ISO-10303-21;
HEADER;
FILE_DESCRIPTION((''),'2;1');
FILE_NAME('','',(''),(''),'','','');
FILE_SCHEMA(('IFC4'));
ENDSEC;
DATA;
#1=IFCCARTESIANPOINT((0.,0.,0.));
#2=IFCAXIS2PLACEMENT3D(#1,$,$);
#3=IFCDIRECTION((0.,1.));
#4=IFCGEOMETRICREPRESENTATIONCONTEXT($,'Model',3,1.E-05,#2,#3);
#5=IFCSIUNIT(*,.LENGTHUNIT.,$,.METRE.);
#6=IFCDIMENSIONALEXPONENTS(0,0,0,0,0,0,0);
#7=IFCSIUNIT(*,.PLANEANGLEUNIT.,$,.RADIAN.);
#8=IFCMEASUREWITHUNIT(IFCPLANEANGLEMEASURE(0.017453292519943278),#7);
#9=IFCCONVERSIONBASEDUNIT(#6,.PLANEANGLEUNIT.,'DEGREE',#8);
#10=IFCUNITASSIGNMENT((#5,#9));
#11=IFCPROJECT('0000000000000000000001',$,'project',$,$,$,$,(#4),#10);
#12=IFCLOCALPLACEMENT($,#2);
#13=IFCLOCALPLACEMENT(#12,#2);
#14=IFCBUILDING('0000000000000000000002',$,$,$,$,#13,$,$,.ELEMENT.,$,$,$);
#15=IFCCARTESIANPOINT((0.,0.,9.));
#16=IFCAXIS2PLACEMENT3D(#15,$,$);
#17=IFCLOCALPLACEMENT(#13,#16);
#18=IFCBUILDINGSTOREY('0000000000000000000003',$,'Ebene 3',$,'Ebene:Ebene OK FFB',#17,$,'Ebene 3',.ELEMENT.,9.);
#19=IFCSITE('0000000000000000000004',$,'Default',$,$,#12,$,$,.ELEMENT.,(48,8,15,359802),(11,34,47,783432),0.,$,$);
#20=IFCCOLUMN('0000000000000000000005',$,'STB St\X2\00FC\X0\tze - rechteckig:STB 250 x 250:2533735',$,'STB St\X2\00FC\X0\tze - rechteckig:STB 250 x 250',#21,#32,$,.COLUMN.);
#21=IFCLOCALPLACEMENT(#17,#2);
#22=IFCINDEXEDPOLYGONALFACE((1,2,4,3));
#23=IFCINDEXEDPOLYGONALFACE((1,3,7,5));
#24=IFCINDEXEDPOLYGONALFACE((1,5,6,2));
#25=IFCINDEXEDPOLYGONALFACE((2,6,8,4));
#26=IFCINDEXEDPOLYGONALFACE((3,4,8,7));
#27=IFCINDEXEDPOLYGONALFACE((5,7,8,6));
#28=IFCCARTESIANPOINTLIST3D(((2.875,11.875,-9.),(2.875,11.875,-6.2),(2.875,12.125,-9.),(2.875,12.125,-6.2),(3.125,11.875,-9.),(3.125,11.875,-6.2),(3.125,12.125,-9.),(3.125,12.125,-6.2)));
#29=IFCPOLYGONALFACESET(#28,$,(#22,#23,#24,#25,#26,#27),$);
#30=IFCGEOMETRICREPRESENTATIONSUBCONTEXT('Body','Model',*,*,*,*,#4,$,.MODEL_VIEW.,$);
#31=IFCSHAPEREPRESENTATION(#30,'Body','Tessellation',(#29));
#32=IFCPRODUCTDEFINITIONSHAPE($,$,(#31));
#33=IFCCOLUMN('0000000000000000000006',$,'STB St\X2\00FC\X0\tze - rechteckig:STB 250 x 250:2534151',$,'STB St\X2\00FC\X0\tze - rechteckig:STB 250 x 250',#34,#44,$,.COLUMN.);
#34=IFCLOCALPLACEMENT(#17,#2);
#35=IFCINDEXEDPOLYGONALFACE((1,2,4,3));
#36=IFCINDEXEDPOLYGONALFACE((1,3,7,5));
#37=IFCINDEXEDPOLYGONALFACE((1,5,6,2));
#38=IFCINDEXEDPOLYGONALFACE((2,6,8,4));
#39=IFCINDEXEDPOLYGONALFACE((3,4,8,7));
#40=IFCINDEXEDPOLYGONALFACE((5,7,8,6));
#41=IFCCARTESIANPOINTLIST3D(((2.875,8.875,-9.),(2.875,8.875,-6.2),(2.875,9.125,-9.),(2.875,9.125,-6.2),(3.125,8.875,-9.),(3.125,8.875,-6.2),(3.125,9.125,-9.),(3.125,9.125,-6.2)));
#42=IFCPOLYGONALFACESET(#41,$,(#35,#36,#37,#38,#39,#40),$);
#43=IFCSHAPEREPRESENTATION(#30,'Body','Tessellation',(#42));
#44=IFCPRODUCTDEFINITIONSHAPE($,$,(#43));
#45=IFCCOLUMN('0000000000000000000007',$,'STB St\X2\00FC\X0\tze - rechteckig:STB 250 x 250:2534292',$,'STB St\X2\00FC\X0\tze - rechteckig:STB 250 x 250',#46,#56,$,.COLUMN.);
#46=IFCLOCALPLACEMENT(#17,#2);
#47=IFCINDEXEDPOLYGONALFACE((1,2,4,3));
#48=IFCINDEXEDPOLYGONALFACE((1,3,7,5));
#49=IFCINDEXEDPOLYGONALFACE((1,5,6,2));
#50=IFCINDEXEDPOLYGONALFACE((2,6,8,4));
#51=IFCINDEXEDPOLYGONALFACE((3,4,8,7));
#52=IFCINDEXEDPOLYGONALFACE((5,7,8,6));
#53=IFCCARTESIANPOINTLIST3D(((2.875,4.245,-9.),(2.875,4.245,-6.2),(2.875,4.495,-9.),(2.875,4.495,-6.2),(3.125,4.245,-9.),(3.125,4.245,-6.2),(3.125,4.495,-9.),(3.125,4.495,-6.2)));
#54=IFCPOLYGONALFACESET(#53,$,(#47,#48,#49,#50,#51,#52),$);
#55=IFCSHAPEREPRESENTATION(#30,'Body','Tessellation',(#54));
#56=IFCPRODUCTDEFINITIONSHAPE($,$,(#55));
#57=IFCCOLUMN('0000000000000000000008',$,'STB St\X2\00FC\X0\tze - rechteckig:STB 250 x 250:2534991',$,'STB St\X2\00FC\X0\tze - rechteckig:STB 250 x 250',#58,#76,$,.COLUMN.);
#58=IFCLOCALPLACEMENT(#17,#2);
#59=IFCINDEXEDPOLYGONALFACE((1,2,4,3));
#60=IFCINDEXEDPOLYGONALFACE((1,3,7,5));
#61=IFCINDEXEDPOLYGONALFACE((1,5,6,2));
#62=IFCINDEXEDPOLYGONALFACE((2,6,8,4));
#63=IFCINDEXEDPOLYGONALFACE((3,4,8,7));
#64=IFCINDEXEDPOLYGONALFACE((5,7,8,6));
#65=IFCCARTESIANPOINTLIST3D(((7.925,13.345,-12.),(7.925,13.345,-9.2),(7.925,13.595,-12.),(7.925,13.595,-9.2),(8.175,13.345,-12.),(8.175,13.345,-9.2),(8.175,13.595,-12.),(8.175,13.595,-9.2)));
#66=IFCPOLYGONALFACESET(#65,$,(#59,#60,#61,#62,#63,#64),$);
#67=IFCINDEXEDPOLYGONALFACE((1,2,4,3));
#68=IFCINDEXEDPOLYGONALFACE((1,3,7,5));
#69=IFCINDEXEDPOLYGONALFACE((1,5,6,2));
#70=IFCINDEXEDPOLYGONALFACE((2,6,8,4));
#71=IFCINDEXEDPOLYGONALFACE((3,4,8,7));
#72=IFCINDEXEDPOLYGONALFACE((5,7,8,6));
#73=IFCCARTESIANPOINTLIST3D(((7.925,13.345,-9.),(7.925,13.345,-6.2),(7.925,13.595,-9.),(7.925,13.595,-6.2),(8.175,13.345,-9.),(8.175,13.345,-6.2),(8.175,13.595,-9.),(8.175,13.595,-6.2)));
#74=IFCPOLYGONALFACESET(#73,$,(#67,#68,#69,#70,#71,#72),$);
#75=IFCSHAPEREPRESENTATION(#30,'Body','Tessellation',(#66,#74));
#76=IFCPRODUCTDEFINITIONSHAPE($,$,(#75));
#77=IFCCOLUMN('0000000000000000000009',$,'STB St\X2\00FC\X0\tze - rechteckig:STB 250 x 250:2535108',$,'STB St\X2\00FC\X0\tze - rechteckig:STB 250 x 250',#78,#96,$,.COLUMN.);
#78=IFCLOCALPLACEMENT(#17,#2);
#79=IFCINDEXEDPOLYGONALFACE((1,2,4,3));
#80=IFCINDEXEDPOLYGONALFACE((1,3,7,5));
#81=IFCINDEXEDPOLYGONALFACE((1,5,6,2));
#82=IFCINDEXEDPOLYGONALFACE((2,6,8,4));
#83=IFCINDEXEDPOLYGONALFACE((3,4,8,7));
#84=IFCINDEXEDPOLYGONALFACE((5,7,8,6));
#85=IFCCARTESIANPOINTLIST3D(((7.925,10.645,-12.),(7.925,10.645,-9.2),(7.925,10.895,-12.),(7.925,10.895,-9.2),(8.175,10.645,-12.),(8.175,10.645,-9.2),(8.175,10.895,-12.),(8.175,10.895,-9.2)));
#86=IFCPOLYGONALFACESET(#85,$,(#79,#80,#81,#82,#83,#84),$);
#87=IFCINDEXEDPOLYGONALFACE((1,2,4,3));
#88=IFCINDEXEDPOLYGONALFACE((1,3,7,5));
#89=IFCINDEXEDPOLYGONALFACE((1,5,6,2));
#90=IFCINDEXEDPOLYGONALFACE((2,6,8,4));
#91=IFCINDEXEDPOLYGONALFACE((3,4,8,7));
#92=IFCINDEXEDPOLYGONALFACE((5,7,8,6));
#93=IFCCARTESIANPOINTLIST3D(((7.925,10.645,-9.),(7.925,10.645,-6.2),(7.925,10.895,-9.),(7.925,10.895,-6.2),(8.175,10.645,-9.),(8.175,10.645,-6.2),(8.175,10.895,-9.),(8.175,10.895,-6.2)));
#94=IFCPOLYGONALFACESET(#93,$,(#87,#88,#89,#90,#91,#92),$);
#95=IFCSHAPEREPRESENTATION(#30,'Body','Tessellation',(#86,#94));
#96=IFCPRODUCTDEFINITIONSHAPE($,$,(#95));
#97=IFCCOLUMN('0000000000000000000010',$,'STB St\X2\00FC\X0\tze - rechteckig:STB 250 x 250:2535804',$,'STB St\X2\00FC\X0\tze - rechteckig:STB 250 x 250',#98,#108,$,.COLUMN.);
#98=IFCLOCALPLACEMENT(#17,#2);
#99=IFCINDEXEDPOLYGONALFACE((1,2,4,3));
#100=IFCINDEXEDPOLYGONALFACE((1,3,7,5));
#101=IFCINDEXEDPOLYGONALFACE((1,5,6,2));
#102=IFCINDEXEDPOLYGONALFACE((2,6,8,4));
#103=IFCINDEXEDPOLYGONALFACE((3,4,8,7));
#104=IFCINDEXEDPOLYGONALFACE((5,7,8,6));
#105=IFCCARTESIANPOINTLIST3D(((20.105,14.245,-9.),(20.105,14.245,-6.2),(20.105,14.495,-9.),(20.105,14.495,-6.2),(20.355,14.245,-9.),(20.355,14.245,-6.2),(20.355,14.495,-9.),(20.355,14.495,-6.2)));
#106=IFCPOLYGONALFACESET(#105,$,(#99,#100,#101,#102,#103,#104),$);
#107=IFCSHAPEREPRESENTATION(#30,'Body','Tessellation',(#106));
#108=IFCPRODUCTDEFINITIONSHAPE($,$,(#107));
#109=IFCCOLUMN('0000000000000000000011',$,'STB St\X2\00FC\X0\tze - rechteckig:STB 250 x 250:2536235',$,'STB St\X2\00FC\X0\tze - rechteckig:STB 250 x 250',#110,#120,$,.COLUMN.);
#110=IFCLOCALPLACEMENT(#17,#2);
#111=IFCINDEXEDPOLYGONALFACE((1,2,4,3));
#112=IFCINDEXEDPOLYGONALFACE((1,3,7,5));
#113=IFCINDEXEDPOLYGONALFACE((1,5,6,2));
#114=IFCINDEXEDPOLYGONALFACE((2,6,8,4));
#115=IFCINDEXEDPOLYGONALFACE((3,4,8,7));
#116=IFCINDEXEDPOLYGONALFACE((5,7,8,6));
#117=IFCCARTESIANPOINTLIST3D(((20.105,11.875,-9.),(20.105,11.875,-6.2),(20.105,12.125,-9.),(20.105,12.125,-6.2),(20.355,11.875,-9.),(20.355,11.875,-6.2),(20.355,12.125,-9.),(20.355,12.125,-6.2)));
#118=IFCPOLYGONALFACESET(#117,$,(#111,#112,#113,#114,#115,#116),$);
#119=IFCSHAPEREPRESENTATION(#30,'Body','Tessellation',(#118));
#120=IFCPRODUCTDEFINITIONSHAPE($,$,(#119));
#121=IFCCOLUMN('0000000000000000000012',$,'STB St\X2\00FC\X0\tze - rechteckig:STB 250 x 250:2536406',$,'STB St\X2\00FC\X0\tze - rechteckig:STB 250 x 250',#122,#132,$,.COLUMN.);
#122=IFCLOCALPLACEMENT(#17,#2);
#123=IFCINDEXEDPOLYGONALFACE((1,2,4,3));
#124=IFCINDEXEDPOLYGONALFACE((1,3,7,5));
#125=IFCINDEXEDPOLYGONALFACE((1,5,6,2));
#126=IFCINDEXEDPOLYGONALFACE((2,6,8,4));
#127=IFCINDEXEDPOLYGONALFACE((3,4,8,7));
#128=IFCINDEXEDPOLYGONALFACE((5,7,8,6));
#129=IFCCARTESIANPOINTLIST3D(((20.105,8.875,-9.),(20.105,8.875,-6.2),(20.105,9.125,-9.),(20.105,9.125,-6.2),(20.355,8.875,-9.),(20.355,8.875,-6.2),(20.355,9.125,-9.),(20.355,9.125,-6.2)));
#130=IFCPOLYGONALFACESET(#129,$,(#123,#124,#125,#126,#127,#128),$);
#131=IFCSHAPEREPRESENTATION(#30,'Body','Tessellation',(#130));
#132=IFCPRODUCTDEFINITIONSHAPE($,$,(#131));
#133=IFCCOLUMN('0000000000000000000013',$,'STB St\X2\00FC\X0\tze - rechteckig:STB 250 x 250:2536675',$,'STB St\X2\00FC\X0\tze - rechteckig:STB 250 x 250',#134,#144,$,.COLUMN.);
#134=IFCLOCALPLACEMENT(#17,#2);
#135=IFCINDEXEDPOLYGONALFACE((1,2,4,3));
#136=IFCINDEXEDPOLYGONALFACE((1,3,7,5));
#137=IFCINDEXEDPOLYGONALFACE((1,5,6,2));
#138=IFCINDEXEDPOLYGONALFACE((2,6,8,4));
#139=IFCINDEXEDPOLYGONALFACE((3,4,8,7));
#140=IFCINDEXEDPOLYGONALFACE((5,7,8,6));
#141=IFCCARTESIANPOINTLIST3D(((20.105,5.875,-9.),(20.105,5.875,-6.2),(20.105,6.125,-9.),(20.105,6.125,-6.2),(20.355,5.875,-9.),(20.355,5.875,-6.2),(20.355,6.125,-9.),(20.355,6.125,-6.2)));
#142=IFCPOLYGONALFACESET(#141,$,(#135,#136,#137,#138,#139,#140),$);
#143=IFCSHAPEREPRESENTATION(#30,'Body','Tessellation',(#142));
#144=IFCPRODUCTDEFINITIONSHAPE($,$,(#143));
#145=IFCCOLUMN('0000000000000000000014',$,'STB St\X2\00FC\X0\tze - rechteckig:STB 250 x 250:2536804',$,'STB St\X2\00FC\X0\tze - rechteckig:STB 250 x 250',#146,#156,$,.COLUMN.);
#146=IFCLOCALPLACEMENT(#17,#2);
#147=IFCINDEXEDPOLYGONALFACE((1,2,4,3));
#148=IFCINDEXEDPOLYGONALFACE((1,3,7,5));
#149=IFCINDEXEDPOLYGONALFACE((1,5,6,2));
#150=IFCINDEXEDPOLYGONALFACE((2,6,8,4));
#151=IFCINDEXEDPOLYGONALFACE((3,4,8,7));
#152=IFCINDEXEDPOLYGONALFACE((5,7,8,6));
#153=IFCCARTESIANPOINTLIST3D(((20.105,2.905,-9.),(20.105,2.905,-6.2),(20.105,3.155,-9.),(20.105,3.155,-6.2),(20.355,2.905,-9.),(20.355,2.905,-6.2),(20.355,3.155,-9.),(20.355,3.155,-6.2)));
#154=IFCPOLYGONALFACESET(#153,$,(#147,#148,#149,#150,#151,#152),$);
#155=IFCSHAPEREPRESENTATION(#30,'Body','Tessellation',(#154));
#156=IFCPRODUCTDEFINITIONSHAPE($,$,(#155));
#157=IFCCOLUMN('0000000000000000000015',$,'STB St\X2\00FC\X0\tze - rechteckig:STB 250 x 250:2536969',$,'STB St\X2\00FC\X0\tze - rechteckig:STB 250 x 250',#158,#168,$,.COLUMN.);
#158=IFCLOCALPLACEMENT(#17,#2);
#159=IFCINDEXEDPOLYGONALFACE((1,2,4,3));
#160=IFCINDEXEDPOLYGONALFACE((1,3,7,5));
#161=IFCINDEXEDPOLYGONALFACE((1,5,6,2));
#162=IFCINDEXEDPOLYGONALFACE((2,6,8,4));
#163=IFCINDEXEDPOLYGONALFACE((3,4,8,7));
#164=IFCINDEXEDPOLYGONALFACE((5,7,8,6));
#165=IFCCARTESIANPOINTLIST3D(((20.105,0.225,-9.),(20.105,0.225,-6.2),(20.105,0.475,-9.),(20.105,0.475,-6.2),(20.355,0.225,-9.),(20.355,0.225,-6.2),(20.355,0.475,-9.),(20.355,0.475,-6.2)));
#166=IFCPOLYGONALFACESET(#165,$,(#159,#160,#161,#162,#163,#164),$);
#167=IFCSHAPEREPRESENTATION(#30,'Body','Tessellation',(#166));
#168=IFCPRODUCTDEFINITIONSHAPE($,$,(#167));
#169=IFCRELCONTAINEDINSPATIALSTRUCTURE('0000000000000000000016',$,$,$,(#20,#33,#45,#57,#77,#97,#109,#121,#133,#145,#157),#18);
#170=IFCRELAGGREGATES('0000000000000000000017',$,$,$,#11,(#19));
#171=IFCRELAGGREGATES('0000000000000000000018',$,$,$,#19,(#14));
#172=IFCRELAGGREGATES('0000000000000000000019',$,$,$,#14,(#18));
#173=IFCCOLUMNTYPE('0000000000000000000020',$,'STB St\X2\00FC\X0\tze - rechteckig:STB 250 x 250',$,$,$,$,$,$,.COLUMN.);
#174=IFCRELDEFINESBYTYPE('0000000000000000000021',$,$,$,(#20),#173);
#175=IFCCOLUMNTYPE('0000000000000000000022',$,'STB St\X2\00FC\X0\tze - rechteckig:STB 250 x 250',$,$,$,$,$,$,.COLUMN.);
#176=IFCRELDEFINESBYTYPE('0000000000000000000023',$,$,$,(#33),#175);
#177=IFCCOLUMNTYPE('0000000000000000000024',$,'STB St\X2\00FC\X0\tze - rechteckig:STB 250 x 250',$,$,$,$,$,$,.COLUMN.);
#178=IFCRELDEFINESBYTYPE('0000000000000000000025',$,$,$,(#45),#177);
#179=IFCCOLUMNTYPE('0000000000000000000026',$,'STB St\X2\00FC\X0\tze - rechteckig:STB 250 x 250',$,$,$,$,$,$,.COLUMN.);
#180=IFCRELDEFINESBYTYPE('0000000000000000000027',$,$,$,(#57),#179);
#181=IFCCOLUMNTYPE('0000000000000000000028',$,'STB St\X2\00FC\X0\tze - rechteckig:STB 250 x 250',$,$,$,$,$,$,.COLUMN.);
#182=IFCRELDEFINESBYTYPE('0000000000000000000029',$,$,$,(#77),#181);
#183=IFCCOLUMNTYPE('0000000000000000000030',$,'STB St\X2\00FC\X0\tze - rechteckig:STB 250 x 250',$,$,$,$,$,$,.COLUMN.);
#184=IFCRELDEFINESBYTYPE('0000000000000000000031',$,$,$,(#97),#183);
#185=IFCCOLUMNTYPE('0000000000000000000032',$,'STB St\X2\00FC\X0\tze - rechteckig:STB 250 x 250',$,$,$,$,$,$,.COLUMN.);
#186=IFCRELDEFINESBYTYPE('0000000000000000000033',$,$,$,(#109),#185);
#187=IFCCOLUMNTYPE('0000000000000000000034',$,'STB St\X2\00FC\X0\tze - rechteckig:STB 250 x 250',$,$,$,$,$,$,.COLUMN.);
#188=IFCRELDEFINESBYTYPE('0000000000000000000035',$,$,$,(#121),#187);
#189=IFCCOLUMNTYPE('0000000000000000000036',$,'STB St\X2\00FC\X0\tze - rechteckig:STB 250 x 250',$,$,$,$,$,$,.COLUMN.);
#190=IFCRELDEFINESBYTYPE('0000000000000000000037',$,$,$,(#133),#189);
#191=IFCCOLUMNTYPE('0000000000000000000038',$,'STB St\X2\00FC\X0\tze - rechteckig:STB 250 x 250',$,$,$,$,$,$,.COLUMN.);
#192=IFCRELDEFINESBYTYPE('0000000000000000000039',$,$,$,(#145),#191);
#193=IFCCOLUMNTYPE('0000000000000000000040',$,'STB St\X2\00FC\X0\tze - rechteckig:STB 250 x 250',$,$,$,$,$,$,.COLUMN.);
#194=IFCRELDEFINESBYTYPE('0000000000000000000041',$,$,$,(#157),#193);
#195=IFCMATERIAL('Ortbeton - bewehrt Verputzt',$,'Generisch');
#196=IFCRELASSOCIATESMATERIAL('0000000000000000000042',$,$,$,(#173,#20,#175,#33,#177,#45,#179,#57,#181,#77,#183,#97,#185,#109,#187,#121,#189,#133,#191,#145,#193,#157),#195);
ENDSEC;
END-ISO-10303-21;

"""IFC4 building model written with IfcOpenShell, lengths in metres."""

from ifc_helpers import new_model, entity, si_unit, converted_unit, direction, frame, origin, place, context, subcontext, project, spatial, indexed_curve, outline, extrude, source, transform, mapped, material, type_object, type_shapes, element, save


model = new_model("IFC4")

# Units and contexts
model_context = context("Model", 3, precision=1e-05, world=origin(), true_north=direction((0.0, 1.0)))
body_context = subcontext(model_context, "Body", "Model", "MODEL_VIEW")
ifc_project = project(units=[si_unit("LENGTHUNIT", "METRE"), converted_unit("PLANEANGLEUNIT", "DEGREE", entity("IfcPlaneAngleMeasure", 0.017453292519943278), si_unit("PLANEANGLEUNIT", "RADIAN"), dimensions=[0, 0, 0, 0, 0, 0, 0])], contexts=[model_context])

# Site, building, storey
site_placement = place(None, origin())
site = spatial("IfcSite", under=ifc_project, at=site_placement, Name="Default", CompositionType="ELEMENT", RefLatitude=(48, 8, 15, 359802), RefLongitude=(11, 34, 47, 783432), RefElevation=0.0)
building_placement = place(site_placement, origin())
building = spatial("IfcBuilding", under=site, at=building_placement, CompositionType="ELEMENT")
storey_placement = place(building_placement, frame((0.0, 0.0, 9.0)))
storey = spatial("IfcBuildingStorey", under=building, at=storey_placement, Name="Ebene 3", ObjectType="Ebene:Ebene OK FFB", LongName="Ebene 3", CompositionType="ELEMENT", Elevation=9.0)

# Columns
ifc_material_1 = material(Name="Ortbeton - bewehrt Verputzt", Category="Generisch")
column_type_1 = type_object("IfcColumnType", Name="STB Stütze - rechteckig:STB 250 x 250", PredefinedType="COLUMN", material=ifc_material_1)
shared_shape_1 = source(origin(), body_context, "Body", "SweptSolid", [
    extrude(outline(indexed_curve([(-0.125, -0.125), (0.125, -0.125), (0.125, 0.125), (-0.125, 0.125), (-0.125, -0.125)], self_intersect=False)), frame((3.0, 12.0, 0.0), z_axis=(0.0, 0.0, 1.0), x_axis=(-1.0, 0.0, 0.0)), (0.0, 0.0, 1.0), 2.8),
])
type_shapes(column_type_1, [shared_shape_1])
column_1_placement = place(storey_placement, frame((0.0, 0.0, -9.0)))
element("IfcColumn", 1, at=column_1_placement, inside=storey, type_object=column_type_1, material=ifc_material_1, Name="STB Stütze - rechteckig:STB 250 x 250:2533735", ObjectType="STB Stütze - rechteckig:STB 250 x 250", PredefinedType="COLUMN", context=body_context, shape_type="MappedRepresentation", body=[
    mapped(shared_shape_1, transform((0.0, 0.0, 0.0), scale=1.0)),
])
column_type_2 = type_object("IfcColumnType", Name="STB Stütze - rechteckig:STB 250 x 250", PredefinedType="COLUMN", material=ifc_material_1)
shared_shape_2 = source(origin(), body_context, "Body", "SweptSolid", [
    extrude(outline(indexed_curve([(-0.125, -0.125), (0.125, -0.125), (0.125, 0.125), (-0.125, 0.125), (-0.125, -0.125)], self_intersect=False)), frame((3.0, 9.0, 0.0), z_axis=(0.0, 0.0, 1.0), x_axis=(-1.0, 0.0, 0.0)), (0.0, 0.0, 1.0), 2.8),
])
type_shapes(column_type_2, [shared_shape_2])
column_2_placement = place(storey_placement, frame((0.0, 0.0, -9.0)))
element("IfcColumn", 2, at=column_2_placement, inside=storey, type_object=column_type_2, material=ifc_material_1, Name="STB Stütze - rechteckig:STB 250 x 250:2534151", ObjectType="STB Stütze - rechteckig:STB 250 x 250", PredefinedType="COLUMN", context=body_context, shape_type="MappedRepresentation", body=[
    mapped(shared_shape_2, transform((0.0, 0.0, 0.0), scale=1.0)),
])
column_type_3 = type_object("IfcColumnType", Name="STB Stütze - rechteckig:STB 250 x 250", PredefinedType="COLUMN", material=ifc_material_1)
shared_shape_3 = source(origin(), body_context, "Body", "SweptSolid", [
    extrude(outline(indexed_curve([(-0.125, -0.125), (0.125, -0.125), (0.125, 0.125), (-0.125, 0.125), (-0.125, -0.125)], self_intersect=False)), frame((3.0, 4.37, 0.0), z_axis=(0.0, 0.0, 1.0), x_axis=(-1.0, 0.0, 0.0)), (0.0, 0.0, 1.0), 2.8),
])
type_shapes(column_type_3, [shared_shape_3])
column_3_placement = place(storey_placement, frame((0.0, 0.0, -9.0)))
element("IfcColumn", 3, at=column_3_placement, inside=storey, type_object=column_type_3, material=ifc_material_1, Name="STB Stütze - rechteckig:STB 250 x 250:2534292", ObjectType="STB Stütze - rechteckig:STB 250 x 250", PredefinedType="COLUMN", context=body_context, shape_type="MappedRepresentation", body=[
    mapped(shared_shape_3, transform((0.0, 0.0, 0.0), scale=1.0)),
])
column_type_4 = type_object("IfcColumnType", Name="STB Stütze - rechteckig:STB 250 x 250", PredefinedType="COLUMN", material=ifc_material_1)
shared_shape_4 = source(origin(), body_context, "Body", "SweptSolid", [
    extrude(outline(indexed_curve([(-0.125, -0.125), (0.125, -0.125), (0.125, 0.125), (-0.125, 0.125), (-0.125, -0.125)], self_intersect=False)), frame((8.05, 13.47, -3.0), z_axis=(0.0, 0.0, 1.0), x_axis=(-1.0, 0.0, 0.0)), (0.0, 0.0, 1.0), 2.8),
    extrude(outline(indexed_curve([(-0.125, -0.125), (0.125, -0.125), (0.125, 0.125), (-0.125, 0.125), (-0.125, -0.125)], self_intersect=False)), frame((8.05, 13.47, 0.0), z_axis=(0.0, 0.0, 1.0), x_axis=(0.0, -1.0, 0.0)), (0.0, 0.0, 1.0), 2.8),
])
type_shapes(column_type_4, [shared_shape_4])
column_4_placement = place(storey_placement, frame((0.0, 0.0, -9.0)))
element("IfcColumn", 4, at=column_4_placement, inside=storey, type_object=column_type_4, material=ifc_material_1, Name="STB Stütze - rechteckig:STB 250 x 250:2534991", ObjectType="STB Stütze - rechteckig:STB 250 x 250", PredefinedType="COLUMN", context=body_context, shape_type="MappedRepresentation", body=[
    mapped(shared_shape_4, transform((0.0, 0.0, 0.0), scale=1.0)),
])
column_type_5 = type_object("IfcColumnType", Name="STB Stütze - rechteckig:STB 250 x 250", PredefinedType="COLUMN", material=ifc_material_1)
shared_shape_5 = source(origin(), body_context, "Body", "SweptSolid", [
    extrude(outline(indexed_curve([(-0.125, -0.125), (0.125, -0.125), (0.125, 0.125), (-0.125, 0.125), (-0.125, -0.125)], self_intersect=False)), frame((8.05, 10.77, -3.0), z_axis=(0.0, 0.0, 1.0), x_axis=(-1.0, 0.0, 0.0)), (0.0, 0.0, 1.0), 2.8),
    extrude(outline(indexed_curve([(-0.125, -0.125), (0.125, -0.125), (0.125, 0.125), (-0.125, 0.125), (-0.125, -0.125)], self_intersect=False)), frame((8.05, 10.77, 0.0), z_axis=(0.0, 0.0, 1.0), x_axis=(0.0, -1.0, 0.0)), (0.0, 0.0, 1.0), 2.8),
])
type_shapes(column_type_5, [shared_shape_5])
column_5_placement = place(storey_placement, frame((0.0, 0.0, -9.0)))
element("IfcColumn", 5, at=column_5_placement, inside=storey, type_object=column_type_5, material=ifc_material_1, Name="STB Stütze - rechteckig:STB 250 x 250:2535108", ObjectType="STB Stütze - rechteckig:STB 250 x 250", PredefinedType="COLUMN", context=body_context, shape_type="MappedRepresentation", body=[
    mapped(shared_shape_5, transform((0.0, 0.0, 0.0), scale=1.0)),
])
column_type_6 = type_object("IfcColumnType", Name="STB Stütze - rechteckig:STB 250 x 250", PredefinedType="COLUMN", material=ifc_material_1)
shared_shape_6 = source(origin(), body_context, "Body", "SweptSolid", [
    extrude(outline(indexed_curve([(-0.125, -0.125), (0.125, -0.125), (0.125, 0.125), (-0.125, 0.125), (-0.125, -0.125)], self_intersect=False)), frame((20.23, 14.37, 0.0), z_axis=(0.0, 0.0, 1.0), x_axis=(-1.0, 0.0, 0.0)), (0.0, 0.0, 1.0), 2.8),
])
type_shapes(column_type_6, [shared_shape_6])
column_6_placement = place(storey_placement, frame((0.0, 0.0, -9.0)))
element("IfcColumn", 6, at=column_6_placement, inside=storey, type_object=column_type_6, material=ifc_material_1, Name="STB Stütze - rechteckig:STB 250 x 250:2535804", ObjectType="STB Stütze - rechteckig:STB 250 x 250", PredefinedType="COLUMN", context=body_context, shape_type="MappedRepresentation", body=[
    mapped(shared_shape_6, transform((0.0, 0.0, 0.0), scale=1.0)),
])
column_type_7 = type_object("IfcColumnType", Name="STB Stütze - rechteckig:STB 250 x 250", PredefinedType="COLUMN", material=ifc_material_1)
shared_shape_7 = source(origin(), body_context, "Body", "SweptSolid", [
    extrude(outline(indexed_curve([(-0.125, -0.125), (0.125, -0.125), (0.125, 0.125), (-0.125, 0.125), (-0.125, -0.125)], self_intersect=False)), frame((20.23, 12.0, 0.0), z_axis=(0.0, 0.0, 1.0), x_axis=(-1.0, 0.0, 0.0)), (0.0, 0.0, 1.0), 2.8),
])
type_shapes(column_type_7, [shared_shape_7])
column_7_placement = place(storey_placement, frame((0.0, 0.0, -9.0)))
element("IfcColumn", 7, at=column_7_placement, inside=storey, type_object=column_type_7, material=ifc_material_1, Name="STB Stütze - rechteckig:STB 250 x 250:2536235", ObjectType="STB Stütze - rechteckig:STB 250 x 250", PredefinedType="COLUMN", context=body_context, shape_type="MappedRepresentation", body=[
    mapped(shared_shape_7, transform((0.0, 0.0, 0.0), scale=1.0)),
])
column_type_8 = type_object("IfcColumnType", Name="STB Stütze - rechteckig:STB 250 x 250", PredefinedType="COLUMN", material=ifc_material_1)
shared_shape_8 = source(origin(), body_context, "Body", "SweptSolid", [
    extrude(outline(indexed_curve([(-0.125, -0.125), (0.125, -0.125), (0.125, 0.125), (-0.125, 0.125), (-0.125, -0.125)], self_intersect=False)), frame((20.23, 9.0, 0.0), z_axis=(0.0, 0.0, 1.0), x_axis=(-1.0, 0.0, 0.0)), (0.0, 0.0, 1.0), 2.8),
])
type_shapes(column_type_8, [shared_shape_8])
column_8_placement = place(storey_placement, frame((0.0, 0.0, -9.0)))
element("IfcColumn", 8, at=column_8_placement, inside=storey, type_object=column_type_8, material=ifc_material_1, Name="STB Stütze - rechteckig:STB 250 x 250:2536406", ObjectType="STB Stütze - rechteckig:STB 250 x 250", PredefinedType="COLUMN", context=body_context, shape_type="MappedRepresentation", body=[
    mapped(shared_shape_8, transform((0.0, 0.0, 0.0), scale=1.0)),
])
column_type_9 = type_object("IfcColumnType", Name="STB Stütze - rechteckig:STB 250 x 250", PredefinedType="COLUMN", material=ifc_material_1)
shared_shape_9 = source(origin(), body_context, "Body", "SweptSolid", [
    extrude(outline(indexed_curve([(-0.125, -0.125), (0.125, -0.125), (0.125, 0.125), (-0.125, 0.125), (-0.125, -0.125)], self_intersect=False)), frame((20.23, 6.0, 0.0), z_axis=(0.0, 0.0, 1.0), x_axis=(-1.0, 0.0, 0.0)), (0.0, 0.0, 1.0), 2.8),
])
type_shapes(column_type_9, [shared_shape_9])
column_9_placement = place(storey_placement, frame((0.0, 0.0, -9.0)))
element("IfcColumn", 9, at=column_9_placement, inside=storey, type_object=column_type_9, material=ifc_material_1, Name="STB Stütze - rechteckig:STB 250 x 250:2536675", ObjectType="STB Stütze - rechteckig:STB 250 x 250", PredefinedType="COLUMN", context=body_context, shape_type="MappedRepresentation", body=[
    mapped(shared_shape_9, transform((0.0, 0.0, 0.0), scale=1.0)),
])
column_type_10 = type_object("IfcColumnType", Name="STB Stütze - rechteckig:STB 250 x 250", PredefinedType="COLUMN", material=ifc_material_1)
shared_shape_10 = source(origin(), body_context, "Body", "SweptSolid", [
    extrude(outline(indexed_curve([(-0.125, -0.125), (0.125, -0.125), (0.125, 0.125), (-0.125, 0.125), (-0.125, -0.125)], self_intersect=False)), frame((20.23, 3.03, 0.0), z_axis=(0.0, 0.0, 1.0), x_axis=(-1.0, 0.0, 0.0)), (0.0, 0.0, 1.0), 2.8),
])
type_shapes(column_type_10, [shared_shape_10])
column_10_placement = place(storey_placement, frame((0.0, 0.0, -9.0)))
element("IfcColumn", 10, at=column_10_placement, inside=storey, type_object=column_type_10, material=ifc_material_1, Name="STB Stütze - rechteckig:STB 250 x 250:2536804", ObjectType="STB Stütze - rechteckig:STB 250 x 250", PredefinedType="COLUMN", context=body_context, shape_type="MappedRepresentation", body=[
    mapped(shared_shape_10, transform((0.0, 0.0, 0.0), scale=1.0)),
])
column_type_11 = type_object("IfcColumnType", Name="STB Stütze - rechteckig:STB 250 x 250", PredefinedType="COLUMN", material=ifc_material_1)
shared_shape_11 = source(origin(), body_context, "Body", "SweptSolid", [
    extrude(outline(indexed_curve([(-0.125, -0.125), (0.125, -0.125), (0.125, 0.125), (-0.125, 0.125), (-0.125, -0.125)], self_intersect=False)), frame((20.23, 0.35, 0.0), z_axis=(0.0, 0.0, 1.0), x_axis=(-1.0, 0.0, 0.0)), (0.0, 0.0, 1.0), 2.8),
])
type_shapes(column_type_11, [shared_shape_11])
column_11_placement = place(storey_placement, frame((0.0, 0.0, -9.0)))
element("IfcColumn", 11, at=column_11_placement, inside=storey, type_object=column_type_11, material=ifc_material_1, Name="STB Stütze - rechteckig:STB 250 x 250:2536969", ObjectType="STB Stütze - rechteckig:STB 250 x 250", PredefinedType="COLUMN", context=body_context, shape_type="MappedRepresentation", body=[
    mapped(shared_shape_11, transform((0.0, 0.0, 0.0), scale=1.0)),
])

save(model, "model.ifc")
